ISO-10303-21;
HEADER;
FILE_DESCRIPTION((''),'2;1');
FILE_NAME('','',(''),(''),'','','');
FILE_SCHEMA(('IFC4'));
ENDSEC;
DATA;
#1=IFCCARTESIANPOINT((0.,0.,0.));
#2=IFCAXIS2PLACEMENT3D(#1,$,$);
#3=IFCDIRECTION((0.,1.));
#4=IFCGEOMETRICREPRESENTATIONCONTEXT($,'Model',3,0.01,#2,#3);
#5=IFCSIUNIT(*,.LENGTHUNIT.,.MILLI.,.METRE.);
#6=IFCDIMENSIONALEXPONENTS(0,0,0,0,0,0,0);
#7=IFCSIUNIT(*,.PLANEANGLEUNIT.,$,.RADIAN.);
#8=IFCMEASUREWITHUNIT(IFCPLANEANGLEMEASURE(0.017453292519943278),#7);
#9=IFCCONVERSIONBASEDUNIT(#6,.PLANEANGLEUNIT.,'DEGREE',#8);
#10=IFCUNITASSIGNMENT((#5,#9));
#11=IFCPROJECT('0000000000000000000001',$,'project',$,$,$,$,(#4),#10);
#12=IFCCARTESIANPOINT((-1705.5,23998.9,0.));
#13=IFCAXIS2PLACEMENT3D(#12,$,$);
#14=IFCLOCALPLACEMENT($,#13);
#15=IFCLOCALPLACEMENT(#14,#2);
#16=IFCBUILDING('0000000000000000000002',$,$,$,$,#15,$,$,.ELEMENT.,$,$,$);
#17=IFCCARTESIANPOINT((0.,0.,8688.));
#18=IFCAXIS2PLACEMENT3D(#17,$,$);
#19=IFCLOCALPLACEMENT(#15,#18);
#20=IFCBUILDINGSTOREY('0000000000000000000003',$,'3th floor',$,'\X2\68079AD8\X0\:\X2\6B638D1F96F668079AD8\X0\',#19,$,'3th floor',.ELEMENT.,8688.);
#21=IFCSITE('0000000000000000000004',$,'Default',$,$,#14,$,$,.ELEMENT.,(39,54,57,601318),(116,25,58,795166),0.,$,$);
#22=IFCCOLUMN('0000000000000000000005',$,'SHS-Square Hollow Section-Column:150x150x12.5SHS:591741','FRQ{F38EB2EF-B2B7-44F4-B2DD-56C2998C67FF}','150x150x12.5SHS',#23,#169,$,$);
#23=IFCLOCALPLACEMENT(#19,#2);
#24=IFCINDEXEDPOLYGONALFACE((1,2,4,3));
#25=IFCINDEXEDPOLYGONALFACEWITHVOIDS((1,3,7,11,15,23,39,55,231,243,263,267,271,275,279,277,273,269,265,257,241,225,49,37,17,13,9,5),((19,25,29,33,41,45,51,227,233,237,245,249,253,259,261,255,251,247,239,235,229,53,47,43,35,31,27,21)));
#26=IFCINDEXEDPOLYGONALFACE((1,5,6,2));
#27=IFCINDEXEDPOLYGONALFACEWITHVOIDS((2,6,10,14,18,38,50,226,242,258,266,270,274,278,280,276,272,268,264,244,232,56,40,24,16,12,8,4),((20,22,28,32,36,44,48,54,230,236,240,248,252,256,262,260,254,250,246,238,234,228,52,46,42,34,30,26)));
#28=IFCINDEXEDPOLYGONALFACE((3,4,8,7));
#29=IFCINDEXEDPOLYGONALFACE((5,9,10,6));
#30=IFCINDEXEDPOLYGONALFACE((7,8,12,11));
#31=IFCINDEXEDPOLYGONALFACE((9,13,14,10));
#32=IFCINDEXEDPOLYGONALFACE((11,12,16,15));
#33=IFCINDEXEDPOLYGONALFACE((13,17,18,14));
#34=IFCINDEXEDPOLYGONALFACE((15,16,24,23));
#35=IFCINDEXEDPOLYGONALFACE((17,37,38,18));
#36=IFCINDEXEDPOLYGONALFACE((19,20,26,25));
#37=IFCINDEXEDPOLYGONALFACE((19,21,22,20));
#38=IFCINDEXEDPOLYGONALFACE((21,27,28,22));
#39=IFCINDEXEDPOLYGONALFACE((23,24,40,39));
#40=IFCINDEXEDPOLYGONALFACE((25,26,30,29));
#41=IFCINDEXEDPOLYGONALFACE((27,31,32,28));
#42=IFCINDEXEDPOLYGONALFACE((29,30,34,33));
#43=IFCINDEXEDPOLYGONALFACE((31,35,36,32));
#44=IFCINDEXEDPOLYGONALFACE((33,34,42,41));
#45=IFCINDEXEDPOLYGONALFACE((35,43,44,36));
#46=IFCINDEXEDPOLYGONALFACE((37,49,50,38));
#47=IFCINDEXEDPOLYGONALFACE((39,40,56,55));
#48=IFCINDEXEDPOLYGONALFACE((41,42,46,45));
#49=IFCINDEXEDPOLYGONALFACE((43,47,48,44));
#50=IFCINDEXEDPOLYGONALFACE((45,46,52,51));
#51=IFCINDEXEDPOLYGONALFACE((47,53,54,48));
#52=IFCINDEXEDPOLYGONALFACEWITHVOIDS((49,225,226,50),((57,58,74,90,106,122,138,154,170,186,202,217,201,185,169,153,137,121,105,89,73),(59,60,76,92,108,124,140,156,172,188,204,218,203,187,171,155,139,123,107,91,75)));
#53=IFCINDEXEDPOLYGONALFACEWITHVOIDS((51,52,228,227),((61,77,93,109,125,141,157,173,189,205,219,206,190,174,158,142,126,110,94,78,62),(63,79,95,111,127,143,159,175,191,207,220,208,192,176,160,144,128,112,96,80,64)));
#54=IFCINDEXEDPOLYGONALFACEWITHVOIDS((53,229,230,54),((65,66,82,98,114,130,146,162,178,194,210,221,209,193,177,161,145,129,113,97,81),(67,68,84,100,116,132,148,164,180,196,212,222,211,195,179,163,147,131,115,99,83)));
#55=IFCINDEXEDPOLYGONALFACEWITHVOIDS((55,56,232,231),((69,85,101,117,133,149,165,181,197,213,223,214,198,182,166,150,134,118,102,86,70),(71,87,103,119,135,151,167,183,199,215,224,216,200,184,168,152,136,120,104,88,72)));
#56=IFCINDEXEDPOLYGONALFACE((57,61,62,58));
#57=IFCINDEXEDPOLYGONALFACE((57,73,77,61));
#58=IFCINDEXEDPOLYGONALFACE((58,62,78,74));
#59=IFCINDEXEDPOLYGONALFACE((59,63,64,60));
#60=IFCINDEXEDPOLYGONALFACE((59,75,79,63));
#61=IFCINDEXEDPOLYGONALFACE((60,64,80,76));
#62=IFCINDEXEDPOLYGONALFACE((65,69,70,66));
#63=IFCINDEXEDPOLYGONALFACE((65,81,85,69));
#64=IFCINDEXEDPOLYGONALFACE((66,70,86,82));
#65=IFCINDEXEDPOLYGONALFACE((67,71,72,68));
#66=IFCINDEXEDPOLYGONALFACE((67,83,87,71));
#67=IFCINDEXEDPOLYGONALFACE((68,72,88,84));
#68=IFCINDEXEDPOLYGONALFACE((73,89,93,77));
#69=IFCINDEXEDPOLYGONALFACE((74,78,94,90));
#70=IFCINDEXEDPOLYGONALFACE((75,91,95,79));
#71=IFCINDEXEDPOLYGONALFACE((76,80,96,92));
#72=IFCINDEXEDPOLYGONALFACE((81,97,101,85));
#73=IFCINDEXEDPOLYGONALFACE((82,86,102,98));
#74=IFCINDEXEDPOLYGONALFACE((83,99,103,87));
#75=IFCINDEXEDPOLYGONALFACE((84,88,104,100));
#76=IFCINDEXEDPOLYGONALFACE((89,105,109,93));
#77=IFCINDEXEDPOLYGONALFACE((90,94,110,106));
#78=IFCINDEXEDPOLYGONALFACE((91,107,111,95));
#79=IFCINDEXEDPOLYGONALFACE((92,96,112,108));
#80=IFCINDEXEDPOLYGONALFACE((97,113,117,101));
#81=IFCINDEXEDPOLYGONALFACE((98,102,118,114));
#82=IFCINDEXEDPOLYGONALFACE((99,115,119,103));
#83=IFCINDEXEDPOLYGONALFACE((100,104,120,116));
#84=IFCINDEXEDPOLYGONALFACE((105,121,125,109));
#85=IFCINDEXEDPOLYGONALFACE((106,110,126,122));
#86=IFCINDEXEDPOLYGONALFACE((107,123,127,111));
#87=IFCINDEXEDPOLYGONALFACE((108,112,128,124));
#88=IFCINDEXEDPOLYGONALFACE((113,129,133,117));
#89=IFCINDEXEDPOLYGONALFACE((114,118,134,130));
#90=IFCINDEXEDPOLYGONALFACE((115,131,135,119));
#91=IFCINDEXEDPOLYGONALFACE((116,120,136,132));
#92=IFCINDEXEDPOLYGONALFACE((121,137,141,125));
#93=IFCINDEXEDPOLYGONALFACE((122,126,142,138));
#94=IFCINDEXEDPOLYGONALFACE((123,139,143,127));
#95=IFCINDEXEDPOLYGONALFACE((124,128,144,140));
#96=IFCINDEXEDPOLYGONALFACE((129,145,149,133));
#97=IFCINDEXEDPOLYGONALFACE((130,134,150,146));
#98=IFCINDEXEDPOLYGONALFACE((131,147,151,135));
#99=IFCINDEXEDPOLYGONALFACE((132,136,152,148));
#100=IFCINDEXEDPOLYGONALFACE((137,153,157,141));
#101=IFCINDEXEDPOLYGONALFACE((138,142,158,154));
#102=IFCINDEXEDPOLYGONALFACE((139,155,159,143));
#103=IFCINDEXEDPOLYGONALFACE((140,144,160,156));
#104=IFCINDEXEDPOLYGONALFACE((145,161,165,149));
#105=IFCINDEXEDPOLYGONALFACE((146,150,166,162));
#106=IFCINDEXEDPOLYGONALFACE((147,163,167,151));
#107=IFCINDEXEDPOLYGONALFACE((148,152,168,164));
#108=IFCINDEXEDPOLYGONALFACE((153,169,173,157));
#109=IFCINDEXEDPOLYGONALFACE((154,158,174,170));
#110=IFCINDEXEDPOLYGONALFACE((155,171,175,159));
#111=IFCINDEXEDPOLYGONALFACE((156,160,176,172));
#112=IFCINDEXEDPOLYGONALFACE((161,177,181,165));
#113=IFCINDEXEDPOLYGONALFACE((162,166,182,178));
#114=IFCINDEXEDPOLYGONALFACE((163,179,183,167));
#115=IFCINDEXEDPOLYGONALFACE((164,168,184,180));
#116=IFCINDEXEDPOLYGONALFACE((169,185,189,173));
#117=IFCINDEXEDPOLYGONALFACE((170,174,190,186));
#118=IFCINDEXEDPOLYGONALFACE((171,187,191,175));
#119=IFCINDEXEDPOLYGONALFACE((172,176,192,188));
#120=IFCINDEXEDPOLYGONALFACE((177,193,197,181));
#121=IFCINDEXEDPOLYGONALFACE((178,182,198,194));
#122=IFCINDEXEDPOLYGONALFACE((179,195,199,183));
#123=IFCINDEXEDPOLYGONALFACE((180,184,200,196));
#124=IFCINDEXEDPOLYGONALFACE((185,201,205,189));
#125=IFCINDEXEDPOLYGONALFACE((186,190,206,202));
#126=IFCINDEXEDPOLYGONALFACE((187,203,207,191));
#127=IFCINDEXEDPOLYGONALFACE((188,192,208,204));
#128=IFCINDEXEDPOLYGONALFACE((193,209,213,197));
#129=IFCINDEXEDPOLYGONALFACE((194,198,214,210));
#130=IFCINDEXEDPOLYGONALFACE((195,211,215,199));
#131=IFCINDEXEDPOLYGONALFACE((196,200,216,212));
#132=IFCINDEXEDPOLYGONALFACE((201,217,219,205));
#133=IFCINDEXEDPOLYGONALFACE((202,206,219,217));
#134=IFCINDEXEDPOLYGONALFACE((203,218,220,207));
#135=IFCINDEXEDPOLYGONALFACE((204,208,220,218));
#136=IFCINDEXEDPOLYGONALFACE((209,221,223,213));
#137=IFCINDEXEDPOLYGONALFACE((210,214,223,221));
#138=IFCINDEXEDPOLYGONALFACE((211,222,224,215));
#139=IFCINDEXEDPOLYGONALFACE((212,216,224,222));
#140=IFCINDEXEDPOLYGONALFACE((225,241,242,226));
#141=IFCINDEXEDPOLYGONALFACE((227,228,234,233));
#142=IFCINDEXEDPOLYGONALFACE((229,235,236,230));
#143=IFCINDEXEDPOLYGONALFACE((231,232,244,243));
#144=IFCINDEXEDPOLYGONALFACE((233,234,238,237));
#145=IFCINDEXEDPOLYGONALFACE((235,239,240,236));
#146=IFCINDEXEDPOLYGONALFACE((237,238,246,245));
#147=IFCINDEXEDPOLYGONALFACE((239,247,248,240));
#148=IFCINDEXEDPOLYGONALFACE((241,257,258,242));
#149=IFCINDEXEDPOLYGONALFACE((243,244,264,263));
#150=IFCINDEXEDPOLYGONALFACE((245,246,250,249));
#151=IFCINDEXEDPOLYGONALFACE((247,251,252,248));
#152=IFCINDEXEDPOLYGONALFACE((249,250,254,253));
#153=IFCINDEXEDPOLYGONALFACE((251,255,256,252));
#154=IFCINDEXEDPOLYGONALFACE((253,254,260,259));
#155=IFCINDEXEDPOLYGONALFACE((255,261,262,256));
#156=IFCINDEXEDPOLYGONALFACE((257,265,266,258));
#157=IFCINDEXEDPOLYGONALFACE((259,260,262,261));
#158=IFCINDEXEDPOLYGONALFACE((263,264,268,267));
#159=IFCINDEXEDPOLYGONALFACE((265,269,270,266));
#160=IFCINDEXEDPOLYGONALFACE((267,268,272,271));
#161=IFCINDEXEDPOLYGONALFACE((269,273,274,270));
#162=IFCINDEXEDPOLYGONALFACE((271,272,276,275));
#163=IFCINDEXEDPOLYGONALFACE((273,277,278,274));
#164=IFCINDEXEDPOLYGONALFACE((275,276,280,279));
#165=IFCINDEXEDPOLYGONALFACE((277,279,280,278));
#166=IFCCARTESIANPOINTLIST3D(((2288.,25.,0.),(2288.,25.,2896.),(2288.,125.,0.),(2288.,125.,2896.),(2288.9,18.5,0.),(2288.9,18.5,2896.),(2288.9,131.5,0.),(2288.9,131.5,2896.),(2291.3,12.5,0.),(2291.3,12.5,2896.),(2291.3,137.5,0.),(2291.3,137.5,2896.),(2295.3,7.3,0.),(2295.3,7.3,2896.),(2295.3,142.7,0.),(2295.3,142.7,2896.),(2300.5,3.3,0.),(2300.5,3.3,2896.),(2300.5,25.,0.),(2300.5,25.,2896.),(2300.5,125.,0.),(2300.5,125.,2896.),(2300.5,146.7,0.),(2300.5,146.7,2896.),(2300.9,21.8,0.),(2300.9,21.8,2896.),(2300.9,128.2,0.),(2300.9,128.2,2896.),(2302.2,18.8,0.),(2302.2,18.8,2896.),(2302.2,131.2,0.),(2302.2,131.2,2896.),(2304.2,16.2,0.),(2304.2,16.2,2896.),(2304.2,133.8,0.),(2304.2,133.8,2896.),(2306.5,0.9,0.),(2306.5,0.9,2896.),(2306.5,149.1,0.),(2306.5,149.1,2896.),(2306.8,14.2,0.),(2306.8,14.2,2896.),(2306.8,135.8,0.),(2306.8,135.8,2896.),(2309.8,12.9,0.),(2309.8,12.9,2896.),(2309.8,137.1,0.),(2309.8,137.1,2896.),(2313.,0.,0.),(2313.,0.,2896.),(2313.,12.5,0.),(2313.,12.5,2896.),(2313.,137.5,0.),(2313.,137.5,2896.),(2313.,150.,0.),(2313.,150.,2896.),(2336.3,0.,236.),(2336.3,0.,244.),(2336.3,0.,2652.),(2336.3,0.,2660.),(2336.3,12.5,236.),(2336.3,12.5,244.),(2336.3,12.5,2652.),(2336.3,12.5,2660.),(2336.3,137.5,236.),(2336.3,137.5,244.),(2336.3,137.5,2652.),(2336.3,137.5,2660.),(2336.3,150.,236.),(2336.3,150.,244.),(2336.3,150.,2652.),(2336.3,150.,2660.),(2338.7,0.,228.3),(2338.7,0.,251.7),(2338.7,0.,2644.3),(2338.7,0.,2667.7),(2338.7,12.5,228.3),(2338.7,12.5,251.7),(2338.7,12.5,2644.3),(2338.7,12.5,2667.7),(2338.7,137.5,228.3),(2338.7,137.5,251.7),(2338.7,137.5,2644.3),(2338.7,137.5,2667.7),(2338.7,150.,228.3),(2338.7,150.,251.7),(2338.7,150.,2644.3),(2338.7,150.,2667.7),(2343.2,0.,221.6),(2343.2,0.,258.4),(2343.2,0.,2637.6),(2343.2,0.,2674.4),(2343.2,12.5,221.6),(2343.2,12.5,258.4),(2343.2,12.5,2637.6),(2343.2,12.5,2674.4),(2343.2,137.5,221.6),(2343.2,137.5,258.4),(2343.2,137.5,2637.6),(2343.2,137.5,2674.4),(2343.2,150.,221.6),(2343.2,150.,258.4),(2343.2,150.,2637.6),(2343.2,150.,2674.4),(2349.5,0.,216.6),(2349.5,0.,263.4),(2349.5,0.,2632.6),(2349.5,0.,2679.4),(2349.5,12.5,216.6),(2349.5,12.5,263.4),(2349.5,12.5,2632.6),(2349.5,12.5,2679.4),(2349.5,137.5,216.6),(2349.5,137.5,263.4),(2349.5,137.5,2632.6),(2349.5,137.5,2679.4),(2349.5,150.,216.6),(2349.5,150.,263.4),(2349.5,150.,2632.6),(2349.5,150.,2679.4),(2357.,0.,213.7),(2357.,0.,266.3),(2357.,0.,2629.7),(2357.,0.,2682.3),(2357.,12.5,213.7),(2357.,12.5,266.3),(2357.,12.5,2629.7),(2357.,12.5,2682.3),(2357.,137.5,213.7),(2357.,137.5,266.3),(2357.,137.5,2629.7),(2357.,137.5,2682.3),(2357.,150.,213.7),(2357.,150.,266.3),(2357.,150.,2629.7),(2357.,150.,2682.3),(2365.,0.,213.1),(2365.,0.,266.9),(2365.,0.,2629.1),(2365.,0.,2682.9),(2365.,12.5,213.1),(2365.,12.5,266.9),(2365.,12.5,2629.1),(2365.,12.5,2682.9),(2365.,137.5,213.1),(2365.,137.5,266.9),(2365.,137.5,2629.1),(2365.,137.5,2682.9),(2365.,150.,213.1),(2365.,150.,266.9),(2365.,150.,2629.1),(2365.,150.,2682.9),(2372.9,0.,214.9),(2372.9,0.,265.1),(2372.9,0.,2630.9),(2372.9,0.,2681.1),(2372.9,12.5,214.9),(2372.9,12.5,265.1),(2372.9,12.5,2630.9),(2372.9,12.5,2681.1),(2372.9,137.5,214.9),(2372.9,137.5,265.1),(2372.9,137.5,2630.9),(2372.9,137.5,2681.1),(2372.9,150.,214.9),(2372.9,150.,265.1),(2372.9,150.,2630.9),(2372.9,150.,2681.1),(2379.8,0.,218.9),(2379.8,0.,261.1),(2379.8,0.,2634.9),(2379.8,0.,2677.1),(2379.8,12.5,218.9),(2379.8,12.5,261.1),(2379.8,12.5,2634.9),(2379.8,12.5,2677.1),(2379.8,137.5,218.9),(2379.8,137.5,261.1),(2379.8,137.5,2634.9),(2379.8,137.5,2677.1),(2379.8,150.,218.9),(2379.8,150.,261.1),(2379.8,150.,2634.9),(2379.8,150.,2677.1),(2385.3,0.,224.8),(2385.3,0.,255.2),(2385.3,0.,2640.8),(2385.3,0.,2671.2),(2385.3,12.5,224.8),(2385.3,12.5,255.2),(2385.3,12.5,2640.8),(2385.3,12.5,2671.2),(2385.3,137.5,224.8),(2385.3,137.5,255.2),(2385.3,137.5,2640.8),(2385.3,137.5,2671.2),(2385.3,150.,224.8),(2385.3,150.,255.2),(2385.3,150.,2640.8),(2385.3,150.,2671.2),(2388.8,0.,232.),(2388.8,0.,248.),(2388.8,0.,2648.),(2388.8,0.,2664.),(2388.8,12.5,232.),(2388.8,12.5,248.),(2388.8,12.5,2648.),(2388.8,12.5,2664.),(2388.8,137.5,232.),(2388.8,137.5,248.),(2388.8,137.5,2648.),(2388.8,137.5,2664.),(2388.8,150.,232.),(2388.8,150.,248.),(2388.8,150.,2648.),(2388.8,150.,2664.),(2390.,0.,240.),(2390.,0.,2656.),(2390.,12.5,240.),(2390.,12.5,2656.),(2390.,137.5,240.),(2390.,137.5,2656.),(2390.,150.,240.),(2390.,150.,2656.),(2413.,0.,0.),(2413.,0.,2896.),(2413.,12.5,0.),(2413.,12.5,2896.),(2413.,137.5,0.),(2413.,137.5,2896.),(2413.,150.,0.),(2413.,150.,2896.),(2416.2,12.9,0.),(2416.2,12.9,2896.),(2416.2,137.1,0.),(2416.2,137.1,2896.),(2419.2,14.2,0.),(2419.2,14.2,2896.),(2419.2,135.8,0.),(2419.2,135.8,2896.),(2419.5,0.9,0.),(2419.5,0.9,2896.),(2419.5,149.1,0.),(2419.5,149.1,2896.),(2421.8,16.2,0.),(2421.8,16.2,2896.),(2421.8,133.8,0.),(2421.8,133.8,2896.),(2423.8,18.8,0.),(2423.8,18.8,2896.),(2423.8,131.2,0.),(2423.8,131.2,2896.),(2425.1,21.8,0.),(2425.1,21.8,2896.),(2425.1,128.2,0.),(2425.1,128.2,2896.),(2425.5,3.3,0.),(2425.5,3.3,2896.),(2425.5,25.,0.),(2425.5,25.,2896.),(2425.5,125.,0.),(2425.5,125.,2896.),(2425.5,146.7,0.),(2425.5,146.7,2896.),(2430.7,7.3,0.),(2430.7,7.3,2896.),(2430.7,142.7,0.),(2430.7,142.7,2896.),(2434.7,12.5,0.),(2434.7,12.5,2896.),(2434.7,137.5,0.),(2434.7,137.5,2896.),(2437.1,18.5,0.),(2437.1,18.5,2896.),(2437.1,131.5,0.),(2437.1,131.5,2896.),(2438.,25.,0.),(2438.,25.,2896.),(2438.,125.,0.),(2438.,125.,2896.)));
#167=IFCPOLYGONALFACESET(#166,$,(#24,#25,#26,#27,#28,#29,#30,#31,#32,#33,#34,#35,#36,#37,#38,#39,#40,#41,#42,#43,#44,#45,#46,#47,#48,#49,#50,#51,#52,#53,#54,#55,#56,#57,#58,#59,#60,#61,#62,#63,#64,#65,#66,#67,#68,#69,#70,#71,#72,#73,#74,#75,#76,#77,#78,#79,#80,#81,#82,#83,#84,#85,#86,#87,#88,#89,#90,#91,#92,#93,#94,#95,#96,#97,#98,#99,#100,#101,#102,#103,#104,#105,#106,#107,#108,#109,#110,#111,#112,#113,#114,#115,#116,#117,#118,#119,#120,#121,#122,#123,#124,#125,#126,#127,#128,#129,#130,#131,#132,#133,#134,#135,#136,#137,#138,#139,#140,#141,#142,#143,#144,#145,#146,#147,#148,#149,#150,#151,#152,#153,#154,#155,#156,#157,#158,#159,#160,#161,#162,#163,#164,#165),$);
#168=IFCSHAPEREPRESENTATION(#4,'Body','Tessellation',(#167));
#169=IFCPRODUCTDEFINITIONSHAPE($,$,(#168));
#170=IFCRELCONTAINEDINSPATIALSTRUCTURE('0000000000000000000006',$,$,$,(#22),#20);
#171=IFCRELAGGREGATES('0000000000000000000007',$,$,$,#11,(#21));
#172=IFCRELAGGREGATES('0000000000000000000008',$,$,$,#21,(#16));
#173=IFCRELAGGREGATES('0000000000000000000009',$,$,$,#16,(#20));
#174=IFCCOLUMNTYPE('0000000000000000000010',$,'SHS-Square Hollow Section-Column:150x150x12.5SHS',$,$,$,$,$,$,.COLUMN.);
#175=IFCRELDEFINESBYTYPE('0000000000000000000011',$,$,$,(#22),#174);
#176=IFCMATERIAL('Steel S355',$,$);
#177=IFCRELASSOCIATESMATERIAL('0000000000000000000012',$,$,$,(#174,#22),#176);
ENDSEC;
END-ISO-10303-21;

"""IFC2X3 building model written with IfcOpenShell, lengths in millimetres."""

from ifc_helpers import new_model, entity, si_unit, converted_unit, direction, frame, frame_2d, origin, origin_2d, place, context, project, spatial, circle_curve, hollow_rectangle, outline, extrude, material, type_object, element, save


model = new_model("IFC2X3")

# Units and contexts
model_context = context("Model", 3, precision=0.01, world=origin(), true_north=direction((0.0, 1.0)))
ifc_project = project(units=[si_unit("LENGTHUNIT", "METRE", prefix="MILLI"), converted_unit("PLANEANGLEUNIT", "DEGREE", entity("IfcPlaneAngleMeasure", 0.017453292519943278), si_unit("PLANEANGLEUNIT", "RADIAN"), dimensions=[0, 0, 0, 0, 0, 0, 0])], contexts=[model_context])

# Site, building, storey
site_placement = place(None, frame((-1705.5, 23998.9, 0.0)))
site = spatial("IfcSite", under=ifc_project, at=site_placement, Name="Default", CompositionType="ELEMENT", RefLatitude=(39, 54, 57, 601318), RefLongitude=(116, 25, 58, 795166), RefElevation=0.0)
building_placement = place(site_placement, origin())
building = spatial("IfcBuilding", under=site, at=building_placement, CompositionType="ELEMENT")
storey_placement = place(building_placement, frame((0.0, 0.0, 8688.0)))
storey = spatial("IfcBuildingStorey", under=building, at=storey_placement, Name="3th floor", ObjectType="标高:正负零标高", LongName="3th floor", CompositionType="ELEMENT", Elevation=8688.0)

# Shared definitions
ifc_material_1 = material(Name="Steel S355")

# Column, openings
column_type_1 = type_object("IfcColumnType", Name="SHS-Square Hollow Section-Column:150x150x12.5SHS", PredefinedType="COLUMN", material=ifc_material_1)
column_1_placement = place(storey_placement, frame((2363.0, 75.0, 2896.0), z_axis=(0.0, 0.0, 1.0), x_axis=(0.0, -1.0, 0.0)))
column_1 = element("IfcColumn", 1, at=column_1_placement, inside=storey, type_object=column_type_1, material=ifc_material_1, Name="SHS-Square Hollow Section-Column:150x150x12.5SHS:591741", Description="FRQ{F38EB2EF-B2B7-44F4-B2DD-56C2998C67FF}", ObjectType="150x150x12.5SHS", context=model_context, shape_type="SweptSolid", body=[
    extrude(hollow_rectangle(XDim=150.0, YDim=150.0, WallThickness=12.5, InnerFilletRadius=12.5, OuterFilletRadius=25.0, at=origin_2d()), origin(), (0.0, 0.0, -1.0), 2896.0),
])
opening_1_placement = place(column_1_placement, frame((-175.1, 0.0, 0.0), z_axis=(1.0, 0.0, 0.0), x_axis=(0.0, 1.0, 0.0)))
element("IfcOpeningElement", 2, at=opening_1_placement, cuts=column_1, ObjectType="Opening", context=model_context, shape_type="SweptSolid", body=[
    extrude(outline(circle_curve(frame_2d((0.0, -240.0), x_axis=(1.0, 0.0)), 27.0)), origin(), (0.0, 0.0, 1.0), 350.2),
])
opening_2_placement = place(column_1_placement, frame((-175.1, 0.0, -2896.0), z_axis=(1.0, 0.0, 0.0), x_axis=(0.0, 1.0, 0.0)))
element("IfcOpeningElement", 3, at=opening_2_placement, cuts=column_1, ObjectType="Opening", context=model_context, shape_type="SweptSolid", body=[
    extrude(outline(circle_curve(frame_2d((0.0, 240.0), x_axis=(1.0, 0.0)), 27.0)), origin(), (0.0, 0.0, 1.0), 350.2),
])

save(model, "model.ifc")
